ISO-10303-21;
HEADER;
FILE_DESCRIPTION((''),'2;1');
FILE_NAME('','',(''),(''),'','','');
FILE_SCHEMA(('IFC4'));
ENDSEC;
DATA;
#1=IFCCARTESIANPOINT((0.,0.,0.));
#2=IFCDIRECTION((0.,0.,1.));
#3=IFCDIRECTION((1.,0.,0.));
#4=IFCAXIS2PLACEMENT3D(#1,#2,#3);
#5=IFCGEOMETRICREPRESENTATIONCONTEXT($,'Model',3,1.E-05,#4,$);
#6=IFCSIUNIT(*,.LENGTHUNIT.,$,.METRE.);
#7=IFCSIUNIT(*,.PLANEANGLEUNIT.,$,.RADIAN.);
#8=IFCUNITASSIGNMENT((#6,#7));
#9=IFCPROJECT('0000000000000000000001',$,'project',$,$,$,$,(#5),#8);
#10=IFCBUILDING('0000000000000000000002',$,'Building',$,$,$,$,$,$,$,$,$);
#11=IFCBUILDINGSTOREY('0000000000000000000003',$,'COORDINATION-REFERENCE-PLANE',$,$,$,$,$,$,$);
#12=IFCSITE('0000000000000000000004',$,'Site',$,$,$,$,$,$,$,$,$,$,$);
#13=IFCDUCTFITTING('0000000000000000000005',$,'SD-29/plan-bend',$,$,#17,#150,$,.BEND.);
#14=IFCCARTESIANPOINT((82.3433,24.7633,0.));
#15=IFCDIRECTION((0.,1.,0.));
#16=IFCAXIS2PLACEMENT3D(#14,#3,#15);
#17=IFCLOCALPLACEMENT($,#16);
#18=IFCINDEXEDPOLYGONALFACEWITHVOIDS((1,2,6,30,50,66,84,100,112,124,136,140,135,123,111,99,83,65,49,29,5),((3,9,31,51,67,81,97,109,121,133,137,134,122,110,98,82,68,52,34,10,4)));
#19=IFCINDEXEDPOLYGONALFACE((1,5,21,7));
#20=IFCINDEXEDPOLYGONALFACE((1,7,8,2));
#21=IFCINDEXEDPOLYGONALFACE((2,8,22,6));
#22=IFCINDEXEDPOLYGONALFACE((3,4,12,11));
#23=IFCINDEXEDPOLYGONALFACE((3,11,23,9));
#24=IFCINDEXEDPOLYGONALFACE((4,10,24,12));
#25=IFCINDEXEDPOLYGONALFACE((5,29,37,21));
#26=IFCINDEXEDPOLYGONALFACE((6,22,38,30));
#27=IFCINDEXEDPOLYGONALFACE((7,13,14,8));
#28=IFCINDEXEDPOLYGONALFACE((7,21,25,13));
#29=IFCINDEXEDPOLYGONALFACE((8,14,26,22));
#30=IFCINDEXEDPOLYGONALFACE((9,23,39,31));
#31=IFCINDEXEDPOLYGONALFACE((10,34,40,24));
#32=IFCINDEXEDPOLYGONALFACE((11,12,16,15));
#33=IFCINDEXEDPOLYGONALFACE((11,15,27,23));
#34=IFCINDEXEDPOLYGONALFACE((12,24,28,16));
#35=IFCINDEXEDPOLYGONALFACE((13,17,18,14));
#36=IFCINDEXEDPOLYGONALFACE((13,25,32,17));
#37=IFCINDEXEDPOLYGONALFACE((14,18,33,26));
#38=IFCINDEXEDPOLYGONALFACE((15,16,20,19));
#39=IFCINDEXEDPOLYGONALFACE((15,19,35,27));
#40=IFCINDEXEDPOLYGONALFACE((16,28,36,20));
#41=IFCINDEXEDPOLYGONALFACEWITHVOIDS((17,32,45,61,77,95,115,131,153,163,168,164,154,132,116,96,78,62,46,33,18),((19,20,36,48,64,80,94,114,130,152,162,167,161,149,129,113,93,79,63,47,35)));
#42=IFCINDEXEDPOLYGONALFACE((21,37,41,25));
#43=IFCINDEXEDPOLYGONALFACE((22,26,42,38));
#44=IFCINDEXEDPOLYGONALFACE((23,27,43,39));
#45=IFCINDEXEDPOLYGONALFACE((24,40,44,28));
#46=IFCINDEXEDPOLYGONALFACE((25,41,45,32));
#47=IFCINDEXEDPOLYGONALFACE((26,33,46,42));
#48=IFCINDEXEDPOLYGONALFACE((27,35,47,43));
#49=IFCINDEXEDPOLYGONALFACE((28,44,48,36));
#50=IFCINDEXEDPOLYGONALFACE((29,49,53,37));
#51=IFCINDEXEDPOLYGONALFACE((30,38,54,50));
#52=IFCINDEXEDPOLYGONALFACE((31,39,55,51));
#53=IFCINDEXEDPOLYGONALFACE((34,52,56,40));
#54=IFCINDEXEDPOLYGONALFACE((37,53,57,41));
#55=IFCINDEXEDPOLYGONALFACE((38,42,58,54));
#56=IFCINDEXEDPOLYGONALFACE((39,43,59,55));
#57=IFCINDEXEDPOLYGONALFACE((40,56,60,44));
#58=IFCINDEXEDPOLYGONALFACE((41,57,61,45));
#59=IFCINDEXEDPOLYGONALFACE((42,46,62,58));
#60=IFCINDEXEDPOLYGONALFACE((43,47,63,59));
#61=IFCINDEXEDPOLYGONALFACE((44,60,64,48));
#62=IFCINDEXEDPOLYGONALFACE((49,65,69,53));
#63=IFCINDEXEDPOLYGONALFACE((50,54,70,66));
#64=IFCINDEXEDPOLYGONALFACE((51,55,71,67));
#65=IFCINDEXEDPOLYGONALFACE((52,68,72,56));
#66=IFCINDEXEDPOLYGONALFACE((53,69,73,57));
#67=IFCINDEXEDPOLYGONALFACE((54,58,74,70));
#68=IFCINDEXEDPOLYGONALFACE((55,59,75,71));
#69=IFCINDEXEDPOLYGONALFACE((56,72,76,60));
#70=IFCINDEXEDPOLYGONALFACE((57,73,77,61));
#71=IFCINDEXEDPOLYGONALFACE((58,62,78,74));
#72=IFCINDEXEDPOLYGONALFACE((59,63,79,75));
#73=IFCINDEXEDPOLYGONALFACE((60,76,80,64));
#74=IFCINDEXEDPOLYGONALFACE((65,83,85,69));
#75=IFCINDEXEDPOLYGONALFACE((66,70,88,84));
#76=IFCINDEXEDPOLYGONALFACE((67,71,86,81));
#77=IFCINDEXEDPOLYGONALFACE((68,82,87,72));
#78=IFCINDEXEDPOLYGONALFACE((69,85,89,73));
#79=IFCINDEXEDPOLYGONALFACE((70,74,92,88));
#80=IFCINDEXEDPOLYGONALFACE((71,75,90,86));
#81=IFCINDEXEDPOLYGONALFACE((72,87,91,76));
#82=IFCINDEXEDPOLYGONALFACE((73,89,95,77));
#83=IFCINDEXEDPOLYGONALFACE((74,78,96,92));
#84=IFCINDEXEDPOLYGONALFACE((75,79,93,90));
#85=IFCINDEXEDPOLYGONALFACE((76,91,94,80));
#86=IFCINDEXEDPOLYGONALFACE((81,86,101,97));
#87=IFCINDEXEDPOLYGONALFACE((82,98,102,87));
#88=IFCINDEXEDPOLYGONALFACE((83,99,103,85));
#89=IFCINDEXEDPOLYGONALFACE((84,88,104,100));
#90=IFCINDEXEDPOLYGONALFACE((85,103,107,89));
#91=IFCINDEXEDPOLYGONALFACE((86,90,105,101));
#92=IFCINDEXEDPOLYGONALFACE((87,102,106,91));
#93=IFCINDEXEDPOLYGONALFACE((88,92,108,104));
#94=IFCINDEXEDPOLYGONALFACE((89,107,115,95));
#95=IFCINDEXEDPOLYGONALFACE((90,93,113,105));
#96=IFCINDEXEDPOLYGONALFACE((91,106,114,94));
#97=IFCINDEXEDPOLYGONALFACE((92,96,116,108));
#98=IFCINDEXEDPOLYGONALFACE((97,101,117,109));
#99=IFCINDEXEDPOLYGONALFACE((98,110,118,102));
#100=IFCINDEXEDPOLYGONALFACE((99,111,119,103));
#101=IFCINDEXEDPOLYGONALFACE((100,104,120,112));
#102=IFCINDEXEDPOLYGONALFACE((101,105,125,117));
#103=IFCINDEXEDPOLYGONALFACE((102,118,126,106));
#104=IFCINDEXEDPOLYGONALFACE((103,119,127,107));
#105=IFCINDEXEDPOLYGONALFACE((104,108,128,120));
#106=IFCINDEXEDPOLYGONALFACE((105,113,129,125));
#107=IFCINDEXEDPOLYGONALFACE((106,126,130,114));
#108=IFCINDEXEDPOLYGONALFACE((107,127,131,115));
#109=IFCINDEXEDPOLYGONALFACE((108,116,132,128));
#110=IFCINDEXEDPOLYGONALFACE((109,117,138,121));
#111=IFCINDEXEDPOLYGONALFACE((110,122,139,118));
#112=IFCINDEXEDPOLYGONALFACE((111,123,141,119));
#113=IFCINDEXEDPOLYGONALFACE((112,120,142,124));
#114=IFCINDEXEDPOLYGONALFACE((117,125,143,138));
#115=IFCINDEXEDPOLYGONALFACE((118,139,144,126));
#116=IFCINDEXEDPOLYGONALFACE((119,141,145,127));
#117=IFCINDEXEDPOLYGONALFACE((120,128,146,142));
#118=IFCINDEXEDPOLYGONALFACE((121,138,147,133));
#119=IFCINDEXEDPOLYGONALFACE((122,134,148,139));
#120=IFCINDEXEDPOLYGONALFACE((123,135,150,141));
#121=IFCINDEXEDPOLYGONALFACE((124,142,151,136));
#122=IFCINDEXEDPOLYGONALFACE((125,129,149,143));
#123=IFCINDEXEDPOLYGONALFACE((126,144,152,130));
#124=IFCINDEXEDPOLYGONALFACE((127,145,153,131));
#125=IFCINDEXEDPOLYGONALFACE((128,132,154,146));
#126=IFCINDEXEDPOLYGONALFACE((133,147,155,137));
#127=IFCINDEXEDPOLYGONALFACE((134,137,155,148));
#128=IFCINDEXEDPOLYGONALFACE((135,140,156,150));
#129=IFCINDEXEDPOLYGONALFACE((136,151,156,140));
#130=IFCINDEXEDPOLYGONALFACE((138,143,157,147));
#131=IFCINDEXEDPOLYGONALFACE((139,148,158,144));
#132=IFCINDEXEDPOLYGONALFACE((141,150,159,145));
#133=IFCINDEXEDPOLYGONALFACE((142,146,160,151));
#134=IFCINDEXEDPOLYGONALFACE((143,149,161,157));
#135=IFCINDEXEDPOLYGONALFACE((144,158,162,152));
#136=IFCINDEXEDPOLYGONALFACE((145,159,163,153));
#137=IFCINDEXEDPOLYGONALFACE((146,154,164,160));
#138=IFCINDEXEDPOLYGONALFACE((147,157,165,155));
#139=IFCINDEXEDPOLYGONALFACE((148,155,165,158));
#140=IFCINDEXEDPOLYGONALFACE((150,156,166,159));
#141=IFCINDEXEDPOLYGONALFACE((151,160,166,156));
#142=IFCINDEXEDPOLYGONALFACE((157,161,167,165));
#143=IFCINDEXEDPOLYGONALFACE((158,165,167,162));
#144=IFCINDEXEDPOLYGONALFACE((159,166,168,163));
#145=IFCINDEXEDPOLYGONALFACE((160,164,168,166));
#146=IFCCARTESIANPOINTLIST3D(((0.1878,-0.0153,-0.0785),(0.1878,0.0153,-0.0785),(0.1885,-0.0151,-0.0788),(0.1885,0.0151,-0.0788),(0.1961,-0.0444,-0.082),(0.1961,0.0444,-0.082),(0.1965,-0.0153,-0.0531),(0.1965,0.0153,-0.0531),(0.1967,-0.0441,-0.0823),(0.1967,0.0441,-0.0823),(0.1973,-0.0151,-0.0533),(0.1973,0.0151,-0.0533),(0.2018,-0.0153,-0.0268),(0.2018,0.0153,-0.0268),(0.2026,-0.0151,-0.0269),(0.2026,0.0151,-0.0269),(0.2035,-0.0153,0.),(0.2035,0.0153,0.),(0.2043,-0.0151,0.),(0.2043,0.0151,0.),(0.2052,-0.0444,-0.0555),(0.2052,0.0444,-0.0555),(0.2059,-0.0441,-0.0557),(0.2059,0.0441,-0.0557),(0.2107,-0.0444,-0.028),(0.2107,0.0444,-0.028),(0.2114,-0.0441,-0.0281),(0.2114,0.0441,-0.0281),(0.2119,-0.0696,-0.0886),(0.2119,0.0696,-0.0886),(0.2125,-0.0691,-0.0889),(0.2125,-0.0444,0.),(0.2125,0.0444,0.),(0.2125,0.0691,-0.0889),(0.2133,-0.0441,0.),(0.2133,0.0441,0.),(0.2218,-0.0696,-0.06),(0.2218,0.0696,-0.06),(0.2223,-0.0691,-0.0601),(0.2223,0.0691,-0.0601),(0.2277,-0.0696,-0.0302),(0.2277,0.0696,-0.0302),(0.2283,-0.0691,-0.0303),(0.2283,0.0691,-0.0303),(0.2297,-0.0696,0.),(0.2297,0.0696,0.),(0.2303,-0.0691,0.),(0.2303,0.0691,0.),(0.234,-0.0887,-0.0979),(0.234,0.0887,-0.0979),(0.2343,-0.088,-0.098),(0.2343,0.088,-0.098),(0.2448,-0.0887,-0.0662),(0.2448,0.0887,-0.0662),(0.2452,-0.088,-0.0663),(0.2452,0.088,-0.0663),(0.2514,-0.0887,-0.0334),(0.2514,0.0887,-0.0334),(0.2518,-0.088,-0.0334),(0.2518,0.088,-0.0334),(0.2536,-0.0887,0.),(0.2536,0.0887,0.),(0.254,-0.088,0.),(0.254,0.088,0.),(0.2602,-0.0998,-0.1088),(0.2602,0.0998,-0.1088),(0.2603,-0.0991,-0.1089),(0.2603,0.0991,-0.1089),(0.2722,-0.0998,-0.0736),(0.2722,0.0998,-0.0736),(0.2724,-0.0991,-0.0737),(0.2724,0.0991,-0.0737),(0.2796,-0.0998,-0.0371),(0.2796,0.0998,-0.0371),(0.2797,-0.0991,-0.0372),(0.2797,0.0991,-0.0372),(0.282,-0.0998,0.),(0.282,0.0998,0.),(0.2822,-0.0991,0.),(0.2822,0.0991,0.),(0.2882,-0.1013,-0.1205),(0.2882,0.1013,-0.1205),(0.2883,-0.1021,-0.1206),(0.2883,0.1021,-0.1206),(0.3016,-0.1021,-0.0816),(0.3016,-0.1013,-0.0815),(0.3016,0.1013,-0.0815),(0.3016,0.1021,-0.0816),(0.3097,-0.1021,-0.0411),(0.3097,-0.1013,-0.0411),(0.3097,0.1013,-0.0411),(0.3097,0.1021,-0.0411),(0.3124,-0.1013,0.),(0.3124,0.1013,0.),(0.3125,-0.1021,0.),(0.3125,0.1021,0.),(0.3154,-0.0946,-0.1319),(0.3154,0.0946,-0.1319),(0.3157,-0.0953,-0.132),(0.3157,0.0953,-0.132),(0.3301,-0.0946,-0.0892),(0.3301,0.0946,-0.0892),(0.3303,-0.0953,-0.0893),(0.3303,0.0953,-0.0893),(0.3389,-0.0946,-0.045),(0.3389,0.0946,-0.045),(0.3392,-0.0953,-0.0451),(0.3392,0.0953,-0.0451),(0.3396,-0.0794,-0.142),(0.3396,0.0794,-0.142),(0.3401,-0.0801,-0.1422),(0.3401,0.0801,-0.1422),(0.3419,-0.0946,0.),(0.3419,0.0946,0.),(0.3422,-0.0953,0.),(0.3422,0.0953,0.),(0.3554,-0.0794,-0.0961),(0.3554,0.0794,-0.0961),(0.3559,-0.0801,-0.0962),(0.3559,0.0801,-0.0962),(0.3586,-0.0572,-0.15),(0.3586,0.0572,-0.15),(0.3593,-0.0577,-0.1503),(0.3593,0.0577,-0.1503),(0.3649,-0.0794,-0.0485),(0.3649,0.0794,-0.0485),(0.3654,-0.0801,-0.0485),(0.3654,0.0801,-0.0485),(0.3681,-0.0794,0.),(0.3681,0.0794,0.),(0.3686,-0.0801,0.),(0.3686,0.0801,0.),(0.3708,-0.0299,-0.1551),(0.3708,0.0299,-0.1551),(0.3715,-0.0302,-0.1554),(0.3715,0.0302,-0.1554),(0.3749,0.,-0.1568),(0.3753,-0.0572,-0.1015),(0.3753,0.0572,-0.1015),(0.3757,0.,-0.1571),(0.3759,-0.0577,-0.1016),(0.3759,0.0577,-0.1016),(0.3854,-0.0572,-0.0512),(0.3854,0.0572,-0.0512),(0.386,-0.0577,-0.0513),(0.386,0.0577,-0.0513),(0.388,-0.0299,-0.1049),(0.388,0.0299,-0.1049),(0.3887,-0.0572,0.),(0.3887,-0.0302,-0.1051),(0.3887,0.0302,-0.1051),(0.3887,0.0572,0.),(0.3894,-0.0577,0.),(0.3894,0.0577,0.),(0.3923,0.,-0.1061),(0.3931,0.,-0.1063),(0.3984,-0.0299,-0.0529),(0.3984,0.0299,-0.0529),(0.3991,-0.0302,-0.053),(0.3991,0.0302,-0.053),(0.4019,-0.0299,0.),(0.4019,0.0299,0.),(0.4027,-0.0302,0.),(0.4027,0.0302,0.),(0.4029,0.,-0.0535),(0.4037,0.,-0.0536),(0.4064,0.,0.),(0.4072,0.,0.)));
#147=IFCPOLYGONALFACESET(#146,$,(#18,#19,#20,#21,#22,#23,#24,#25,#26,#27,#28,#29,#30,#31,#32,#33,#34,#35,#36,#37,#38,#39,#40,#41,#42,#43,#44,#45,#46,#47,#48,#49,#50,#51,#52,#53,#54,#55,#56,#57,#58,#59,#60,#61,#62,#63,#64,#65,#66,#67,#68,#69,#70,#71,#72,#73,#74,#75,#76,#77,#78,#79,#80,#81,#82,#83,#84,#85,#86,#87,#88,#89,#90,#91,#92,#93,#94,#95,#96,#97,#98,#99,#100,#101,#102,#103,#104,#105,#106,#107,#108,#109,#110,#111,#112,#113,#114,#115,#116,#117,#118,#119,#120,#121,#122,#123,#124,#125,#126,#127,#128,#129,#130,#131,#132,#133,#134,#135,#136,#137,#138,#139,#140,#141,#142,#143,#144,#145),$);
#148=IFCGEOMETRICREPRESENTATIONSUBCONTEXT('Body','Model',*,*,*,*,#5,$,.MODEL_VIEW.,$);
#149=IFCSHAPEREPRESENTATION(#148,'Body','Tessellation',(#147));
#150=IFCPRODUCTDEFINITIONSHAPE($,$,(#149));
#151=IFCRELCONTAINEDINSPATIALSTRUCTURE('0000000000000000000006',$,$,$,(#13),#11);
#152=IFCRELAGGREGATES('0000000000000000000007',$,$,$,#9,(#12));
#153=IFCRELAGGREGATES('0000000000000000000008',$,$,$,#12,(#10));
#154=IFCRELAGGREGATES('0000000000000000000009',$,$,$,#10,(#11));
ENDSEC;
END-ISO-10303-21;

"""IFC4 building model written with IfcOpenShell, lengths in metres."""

from ifc_helpers import new_model, entity, si_unit, frame, origin_with_axes, place, context, subcontext, project, spatial, element, save


model = new_model("IFC4")

# Units and contexts
model_context = context("Model", 3, precision=1e-05, world=origin_with_axes())
body_context_1 = subcontext(model_context, "Body", "Model", "MODEL_VIEW")
ifc_project = project(units=[si_unit("LENGTHUNIT", "METRE"), si_unit("PLANEANGLEUNIT", "RADIAN")], contexts=[model_context])

# Site, building, storey
site = spatial("IfcSite", under=ifc_project, Name="Site")
building = spatial("IfcBuilding", under=site, Name="Building")
storey = spatial("IfcBuildingStorey", under=building, Name="COORDINATION-REFERENCE-PLANE")

# Duct fitting
duct_fitting_1_placement = place(None, frame((82.3433, 24.7633, 0.0), z_axis=(1.0, 0.0, 0.0), x_axis=(0.0, 1.0, 0.0)))
element("IfcDuctFitting", 1, at=duct_fitting_1_placement, inside=storey, Name="SD-29/plan-bend", PredefinedType="BEND", context=body_context_1, shape_type="SweptSolid", body=[
    entity("IfcRevolvedAreaSolid", entity("IfcCircleHollowProfileDef", "AREA", None, entity("IfcAxis2Placement2D", entity("IfcCartesianPoint", [0.3048, 0.0])), 0.1024, 0.0008), entity("IfcAxis2Placement3D", entity("IfcCartesianPoint", [0.0, 0.0, 0.0]), entity("IfcDirection", [0.0, 0.0, 1.0]), entity("IfcDirection", [1.0, 0.0, 0.0])), entity("IfcAxis1Placement", entity("IfcCartesianPoint", [0.0, 0.0, 0.0]), entity("IfcDirection", [0.0, 1.0, 0.0])), 0.396124),
])

save(model, "model.ifc")
